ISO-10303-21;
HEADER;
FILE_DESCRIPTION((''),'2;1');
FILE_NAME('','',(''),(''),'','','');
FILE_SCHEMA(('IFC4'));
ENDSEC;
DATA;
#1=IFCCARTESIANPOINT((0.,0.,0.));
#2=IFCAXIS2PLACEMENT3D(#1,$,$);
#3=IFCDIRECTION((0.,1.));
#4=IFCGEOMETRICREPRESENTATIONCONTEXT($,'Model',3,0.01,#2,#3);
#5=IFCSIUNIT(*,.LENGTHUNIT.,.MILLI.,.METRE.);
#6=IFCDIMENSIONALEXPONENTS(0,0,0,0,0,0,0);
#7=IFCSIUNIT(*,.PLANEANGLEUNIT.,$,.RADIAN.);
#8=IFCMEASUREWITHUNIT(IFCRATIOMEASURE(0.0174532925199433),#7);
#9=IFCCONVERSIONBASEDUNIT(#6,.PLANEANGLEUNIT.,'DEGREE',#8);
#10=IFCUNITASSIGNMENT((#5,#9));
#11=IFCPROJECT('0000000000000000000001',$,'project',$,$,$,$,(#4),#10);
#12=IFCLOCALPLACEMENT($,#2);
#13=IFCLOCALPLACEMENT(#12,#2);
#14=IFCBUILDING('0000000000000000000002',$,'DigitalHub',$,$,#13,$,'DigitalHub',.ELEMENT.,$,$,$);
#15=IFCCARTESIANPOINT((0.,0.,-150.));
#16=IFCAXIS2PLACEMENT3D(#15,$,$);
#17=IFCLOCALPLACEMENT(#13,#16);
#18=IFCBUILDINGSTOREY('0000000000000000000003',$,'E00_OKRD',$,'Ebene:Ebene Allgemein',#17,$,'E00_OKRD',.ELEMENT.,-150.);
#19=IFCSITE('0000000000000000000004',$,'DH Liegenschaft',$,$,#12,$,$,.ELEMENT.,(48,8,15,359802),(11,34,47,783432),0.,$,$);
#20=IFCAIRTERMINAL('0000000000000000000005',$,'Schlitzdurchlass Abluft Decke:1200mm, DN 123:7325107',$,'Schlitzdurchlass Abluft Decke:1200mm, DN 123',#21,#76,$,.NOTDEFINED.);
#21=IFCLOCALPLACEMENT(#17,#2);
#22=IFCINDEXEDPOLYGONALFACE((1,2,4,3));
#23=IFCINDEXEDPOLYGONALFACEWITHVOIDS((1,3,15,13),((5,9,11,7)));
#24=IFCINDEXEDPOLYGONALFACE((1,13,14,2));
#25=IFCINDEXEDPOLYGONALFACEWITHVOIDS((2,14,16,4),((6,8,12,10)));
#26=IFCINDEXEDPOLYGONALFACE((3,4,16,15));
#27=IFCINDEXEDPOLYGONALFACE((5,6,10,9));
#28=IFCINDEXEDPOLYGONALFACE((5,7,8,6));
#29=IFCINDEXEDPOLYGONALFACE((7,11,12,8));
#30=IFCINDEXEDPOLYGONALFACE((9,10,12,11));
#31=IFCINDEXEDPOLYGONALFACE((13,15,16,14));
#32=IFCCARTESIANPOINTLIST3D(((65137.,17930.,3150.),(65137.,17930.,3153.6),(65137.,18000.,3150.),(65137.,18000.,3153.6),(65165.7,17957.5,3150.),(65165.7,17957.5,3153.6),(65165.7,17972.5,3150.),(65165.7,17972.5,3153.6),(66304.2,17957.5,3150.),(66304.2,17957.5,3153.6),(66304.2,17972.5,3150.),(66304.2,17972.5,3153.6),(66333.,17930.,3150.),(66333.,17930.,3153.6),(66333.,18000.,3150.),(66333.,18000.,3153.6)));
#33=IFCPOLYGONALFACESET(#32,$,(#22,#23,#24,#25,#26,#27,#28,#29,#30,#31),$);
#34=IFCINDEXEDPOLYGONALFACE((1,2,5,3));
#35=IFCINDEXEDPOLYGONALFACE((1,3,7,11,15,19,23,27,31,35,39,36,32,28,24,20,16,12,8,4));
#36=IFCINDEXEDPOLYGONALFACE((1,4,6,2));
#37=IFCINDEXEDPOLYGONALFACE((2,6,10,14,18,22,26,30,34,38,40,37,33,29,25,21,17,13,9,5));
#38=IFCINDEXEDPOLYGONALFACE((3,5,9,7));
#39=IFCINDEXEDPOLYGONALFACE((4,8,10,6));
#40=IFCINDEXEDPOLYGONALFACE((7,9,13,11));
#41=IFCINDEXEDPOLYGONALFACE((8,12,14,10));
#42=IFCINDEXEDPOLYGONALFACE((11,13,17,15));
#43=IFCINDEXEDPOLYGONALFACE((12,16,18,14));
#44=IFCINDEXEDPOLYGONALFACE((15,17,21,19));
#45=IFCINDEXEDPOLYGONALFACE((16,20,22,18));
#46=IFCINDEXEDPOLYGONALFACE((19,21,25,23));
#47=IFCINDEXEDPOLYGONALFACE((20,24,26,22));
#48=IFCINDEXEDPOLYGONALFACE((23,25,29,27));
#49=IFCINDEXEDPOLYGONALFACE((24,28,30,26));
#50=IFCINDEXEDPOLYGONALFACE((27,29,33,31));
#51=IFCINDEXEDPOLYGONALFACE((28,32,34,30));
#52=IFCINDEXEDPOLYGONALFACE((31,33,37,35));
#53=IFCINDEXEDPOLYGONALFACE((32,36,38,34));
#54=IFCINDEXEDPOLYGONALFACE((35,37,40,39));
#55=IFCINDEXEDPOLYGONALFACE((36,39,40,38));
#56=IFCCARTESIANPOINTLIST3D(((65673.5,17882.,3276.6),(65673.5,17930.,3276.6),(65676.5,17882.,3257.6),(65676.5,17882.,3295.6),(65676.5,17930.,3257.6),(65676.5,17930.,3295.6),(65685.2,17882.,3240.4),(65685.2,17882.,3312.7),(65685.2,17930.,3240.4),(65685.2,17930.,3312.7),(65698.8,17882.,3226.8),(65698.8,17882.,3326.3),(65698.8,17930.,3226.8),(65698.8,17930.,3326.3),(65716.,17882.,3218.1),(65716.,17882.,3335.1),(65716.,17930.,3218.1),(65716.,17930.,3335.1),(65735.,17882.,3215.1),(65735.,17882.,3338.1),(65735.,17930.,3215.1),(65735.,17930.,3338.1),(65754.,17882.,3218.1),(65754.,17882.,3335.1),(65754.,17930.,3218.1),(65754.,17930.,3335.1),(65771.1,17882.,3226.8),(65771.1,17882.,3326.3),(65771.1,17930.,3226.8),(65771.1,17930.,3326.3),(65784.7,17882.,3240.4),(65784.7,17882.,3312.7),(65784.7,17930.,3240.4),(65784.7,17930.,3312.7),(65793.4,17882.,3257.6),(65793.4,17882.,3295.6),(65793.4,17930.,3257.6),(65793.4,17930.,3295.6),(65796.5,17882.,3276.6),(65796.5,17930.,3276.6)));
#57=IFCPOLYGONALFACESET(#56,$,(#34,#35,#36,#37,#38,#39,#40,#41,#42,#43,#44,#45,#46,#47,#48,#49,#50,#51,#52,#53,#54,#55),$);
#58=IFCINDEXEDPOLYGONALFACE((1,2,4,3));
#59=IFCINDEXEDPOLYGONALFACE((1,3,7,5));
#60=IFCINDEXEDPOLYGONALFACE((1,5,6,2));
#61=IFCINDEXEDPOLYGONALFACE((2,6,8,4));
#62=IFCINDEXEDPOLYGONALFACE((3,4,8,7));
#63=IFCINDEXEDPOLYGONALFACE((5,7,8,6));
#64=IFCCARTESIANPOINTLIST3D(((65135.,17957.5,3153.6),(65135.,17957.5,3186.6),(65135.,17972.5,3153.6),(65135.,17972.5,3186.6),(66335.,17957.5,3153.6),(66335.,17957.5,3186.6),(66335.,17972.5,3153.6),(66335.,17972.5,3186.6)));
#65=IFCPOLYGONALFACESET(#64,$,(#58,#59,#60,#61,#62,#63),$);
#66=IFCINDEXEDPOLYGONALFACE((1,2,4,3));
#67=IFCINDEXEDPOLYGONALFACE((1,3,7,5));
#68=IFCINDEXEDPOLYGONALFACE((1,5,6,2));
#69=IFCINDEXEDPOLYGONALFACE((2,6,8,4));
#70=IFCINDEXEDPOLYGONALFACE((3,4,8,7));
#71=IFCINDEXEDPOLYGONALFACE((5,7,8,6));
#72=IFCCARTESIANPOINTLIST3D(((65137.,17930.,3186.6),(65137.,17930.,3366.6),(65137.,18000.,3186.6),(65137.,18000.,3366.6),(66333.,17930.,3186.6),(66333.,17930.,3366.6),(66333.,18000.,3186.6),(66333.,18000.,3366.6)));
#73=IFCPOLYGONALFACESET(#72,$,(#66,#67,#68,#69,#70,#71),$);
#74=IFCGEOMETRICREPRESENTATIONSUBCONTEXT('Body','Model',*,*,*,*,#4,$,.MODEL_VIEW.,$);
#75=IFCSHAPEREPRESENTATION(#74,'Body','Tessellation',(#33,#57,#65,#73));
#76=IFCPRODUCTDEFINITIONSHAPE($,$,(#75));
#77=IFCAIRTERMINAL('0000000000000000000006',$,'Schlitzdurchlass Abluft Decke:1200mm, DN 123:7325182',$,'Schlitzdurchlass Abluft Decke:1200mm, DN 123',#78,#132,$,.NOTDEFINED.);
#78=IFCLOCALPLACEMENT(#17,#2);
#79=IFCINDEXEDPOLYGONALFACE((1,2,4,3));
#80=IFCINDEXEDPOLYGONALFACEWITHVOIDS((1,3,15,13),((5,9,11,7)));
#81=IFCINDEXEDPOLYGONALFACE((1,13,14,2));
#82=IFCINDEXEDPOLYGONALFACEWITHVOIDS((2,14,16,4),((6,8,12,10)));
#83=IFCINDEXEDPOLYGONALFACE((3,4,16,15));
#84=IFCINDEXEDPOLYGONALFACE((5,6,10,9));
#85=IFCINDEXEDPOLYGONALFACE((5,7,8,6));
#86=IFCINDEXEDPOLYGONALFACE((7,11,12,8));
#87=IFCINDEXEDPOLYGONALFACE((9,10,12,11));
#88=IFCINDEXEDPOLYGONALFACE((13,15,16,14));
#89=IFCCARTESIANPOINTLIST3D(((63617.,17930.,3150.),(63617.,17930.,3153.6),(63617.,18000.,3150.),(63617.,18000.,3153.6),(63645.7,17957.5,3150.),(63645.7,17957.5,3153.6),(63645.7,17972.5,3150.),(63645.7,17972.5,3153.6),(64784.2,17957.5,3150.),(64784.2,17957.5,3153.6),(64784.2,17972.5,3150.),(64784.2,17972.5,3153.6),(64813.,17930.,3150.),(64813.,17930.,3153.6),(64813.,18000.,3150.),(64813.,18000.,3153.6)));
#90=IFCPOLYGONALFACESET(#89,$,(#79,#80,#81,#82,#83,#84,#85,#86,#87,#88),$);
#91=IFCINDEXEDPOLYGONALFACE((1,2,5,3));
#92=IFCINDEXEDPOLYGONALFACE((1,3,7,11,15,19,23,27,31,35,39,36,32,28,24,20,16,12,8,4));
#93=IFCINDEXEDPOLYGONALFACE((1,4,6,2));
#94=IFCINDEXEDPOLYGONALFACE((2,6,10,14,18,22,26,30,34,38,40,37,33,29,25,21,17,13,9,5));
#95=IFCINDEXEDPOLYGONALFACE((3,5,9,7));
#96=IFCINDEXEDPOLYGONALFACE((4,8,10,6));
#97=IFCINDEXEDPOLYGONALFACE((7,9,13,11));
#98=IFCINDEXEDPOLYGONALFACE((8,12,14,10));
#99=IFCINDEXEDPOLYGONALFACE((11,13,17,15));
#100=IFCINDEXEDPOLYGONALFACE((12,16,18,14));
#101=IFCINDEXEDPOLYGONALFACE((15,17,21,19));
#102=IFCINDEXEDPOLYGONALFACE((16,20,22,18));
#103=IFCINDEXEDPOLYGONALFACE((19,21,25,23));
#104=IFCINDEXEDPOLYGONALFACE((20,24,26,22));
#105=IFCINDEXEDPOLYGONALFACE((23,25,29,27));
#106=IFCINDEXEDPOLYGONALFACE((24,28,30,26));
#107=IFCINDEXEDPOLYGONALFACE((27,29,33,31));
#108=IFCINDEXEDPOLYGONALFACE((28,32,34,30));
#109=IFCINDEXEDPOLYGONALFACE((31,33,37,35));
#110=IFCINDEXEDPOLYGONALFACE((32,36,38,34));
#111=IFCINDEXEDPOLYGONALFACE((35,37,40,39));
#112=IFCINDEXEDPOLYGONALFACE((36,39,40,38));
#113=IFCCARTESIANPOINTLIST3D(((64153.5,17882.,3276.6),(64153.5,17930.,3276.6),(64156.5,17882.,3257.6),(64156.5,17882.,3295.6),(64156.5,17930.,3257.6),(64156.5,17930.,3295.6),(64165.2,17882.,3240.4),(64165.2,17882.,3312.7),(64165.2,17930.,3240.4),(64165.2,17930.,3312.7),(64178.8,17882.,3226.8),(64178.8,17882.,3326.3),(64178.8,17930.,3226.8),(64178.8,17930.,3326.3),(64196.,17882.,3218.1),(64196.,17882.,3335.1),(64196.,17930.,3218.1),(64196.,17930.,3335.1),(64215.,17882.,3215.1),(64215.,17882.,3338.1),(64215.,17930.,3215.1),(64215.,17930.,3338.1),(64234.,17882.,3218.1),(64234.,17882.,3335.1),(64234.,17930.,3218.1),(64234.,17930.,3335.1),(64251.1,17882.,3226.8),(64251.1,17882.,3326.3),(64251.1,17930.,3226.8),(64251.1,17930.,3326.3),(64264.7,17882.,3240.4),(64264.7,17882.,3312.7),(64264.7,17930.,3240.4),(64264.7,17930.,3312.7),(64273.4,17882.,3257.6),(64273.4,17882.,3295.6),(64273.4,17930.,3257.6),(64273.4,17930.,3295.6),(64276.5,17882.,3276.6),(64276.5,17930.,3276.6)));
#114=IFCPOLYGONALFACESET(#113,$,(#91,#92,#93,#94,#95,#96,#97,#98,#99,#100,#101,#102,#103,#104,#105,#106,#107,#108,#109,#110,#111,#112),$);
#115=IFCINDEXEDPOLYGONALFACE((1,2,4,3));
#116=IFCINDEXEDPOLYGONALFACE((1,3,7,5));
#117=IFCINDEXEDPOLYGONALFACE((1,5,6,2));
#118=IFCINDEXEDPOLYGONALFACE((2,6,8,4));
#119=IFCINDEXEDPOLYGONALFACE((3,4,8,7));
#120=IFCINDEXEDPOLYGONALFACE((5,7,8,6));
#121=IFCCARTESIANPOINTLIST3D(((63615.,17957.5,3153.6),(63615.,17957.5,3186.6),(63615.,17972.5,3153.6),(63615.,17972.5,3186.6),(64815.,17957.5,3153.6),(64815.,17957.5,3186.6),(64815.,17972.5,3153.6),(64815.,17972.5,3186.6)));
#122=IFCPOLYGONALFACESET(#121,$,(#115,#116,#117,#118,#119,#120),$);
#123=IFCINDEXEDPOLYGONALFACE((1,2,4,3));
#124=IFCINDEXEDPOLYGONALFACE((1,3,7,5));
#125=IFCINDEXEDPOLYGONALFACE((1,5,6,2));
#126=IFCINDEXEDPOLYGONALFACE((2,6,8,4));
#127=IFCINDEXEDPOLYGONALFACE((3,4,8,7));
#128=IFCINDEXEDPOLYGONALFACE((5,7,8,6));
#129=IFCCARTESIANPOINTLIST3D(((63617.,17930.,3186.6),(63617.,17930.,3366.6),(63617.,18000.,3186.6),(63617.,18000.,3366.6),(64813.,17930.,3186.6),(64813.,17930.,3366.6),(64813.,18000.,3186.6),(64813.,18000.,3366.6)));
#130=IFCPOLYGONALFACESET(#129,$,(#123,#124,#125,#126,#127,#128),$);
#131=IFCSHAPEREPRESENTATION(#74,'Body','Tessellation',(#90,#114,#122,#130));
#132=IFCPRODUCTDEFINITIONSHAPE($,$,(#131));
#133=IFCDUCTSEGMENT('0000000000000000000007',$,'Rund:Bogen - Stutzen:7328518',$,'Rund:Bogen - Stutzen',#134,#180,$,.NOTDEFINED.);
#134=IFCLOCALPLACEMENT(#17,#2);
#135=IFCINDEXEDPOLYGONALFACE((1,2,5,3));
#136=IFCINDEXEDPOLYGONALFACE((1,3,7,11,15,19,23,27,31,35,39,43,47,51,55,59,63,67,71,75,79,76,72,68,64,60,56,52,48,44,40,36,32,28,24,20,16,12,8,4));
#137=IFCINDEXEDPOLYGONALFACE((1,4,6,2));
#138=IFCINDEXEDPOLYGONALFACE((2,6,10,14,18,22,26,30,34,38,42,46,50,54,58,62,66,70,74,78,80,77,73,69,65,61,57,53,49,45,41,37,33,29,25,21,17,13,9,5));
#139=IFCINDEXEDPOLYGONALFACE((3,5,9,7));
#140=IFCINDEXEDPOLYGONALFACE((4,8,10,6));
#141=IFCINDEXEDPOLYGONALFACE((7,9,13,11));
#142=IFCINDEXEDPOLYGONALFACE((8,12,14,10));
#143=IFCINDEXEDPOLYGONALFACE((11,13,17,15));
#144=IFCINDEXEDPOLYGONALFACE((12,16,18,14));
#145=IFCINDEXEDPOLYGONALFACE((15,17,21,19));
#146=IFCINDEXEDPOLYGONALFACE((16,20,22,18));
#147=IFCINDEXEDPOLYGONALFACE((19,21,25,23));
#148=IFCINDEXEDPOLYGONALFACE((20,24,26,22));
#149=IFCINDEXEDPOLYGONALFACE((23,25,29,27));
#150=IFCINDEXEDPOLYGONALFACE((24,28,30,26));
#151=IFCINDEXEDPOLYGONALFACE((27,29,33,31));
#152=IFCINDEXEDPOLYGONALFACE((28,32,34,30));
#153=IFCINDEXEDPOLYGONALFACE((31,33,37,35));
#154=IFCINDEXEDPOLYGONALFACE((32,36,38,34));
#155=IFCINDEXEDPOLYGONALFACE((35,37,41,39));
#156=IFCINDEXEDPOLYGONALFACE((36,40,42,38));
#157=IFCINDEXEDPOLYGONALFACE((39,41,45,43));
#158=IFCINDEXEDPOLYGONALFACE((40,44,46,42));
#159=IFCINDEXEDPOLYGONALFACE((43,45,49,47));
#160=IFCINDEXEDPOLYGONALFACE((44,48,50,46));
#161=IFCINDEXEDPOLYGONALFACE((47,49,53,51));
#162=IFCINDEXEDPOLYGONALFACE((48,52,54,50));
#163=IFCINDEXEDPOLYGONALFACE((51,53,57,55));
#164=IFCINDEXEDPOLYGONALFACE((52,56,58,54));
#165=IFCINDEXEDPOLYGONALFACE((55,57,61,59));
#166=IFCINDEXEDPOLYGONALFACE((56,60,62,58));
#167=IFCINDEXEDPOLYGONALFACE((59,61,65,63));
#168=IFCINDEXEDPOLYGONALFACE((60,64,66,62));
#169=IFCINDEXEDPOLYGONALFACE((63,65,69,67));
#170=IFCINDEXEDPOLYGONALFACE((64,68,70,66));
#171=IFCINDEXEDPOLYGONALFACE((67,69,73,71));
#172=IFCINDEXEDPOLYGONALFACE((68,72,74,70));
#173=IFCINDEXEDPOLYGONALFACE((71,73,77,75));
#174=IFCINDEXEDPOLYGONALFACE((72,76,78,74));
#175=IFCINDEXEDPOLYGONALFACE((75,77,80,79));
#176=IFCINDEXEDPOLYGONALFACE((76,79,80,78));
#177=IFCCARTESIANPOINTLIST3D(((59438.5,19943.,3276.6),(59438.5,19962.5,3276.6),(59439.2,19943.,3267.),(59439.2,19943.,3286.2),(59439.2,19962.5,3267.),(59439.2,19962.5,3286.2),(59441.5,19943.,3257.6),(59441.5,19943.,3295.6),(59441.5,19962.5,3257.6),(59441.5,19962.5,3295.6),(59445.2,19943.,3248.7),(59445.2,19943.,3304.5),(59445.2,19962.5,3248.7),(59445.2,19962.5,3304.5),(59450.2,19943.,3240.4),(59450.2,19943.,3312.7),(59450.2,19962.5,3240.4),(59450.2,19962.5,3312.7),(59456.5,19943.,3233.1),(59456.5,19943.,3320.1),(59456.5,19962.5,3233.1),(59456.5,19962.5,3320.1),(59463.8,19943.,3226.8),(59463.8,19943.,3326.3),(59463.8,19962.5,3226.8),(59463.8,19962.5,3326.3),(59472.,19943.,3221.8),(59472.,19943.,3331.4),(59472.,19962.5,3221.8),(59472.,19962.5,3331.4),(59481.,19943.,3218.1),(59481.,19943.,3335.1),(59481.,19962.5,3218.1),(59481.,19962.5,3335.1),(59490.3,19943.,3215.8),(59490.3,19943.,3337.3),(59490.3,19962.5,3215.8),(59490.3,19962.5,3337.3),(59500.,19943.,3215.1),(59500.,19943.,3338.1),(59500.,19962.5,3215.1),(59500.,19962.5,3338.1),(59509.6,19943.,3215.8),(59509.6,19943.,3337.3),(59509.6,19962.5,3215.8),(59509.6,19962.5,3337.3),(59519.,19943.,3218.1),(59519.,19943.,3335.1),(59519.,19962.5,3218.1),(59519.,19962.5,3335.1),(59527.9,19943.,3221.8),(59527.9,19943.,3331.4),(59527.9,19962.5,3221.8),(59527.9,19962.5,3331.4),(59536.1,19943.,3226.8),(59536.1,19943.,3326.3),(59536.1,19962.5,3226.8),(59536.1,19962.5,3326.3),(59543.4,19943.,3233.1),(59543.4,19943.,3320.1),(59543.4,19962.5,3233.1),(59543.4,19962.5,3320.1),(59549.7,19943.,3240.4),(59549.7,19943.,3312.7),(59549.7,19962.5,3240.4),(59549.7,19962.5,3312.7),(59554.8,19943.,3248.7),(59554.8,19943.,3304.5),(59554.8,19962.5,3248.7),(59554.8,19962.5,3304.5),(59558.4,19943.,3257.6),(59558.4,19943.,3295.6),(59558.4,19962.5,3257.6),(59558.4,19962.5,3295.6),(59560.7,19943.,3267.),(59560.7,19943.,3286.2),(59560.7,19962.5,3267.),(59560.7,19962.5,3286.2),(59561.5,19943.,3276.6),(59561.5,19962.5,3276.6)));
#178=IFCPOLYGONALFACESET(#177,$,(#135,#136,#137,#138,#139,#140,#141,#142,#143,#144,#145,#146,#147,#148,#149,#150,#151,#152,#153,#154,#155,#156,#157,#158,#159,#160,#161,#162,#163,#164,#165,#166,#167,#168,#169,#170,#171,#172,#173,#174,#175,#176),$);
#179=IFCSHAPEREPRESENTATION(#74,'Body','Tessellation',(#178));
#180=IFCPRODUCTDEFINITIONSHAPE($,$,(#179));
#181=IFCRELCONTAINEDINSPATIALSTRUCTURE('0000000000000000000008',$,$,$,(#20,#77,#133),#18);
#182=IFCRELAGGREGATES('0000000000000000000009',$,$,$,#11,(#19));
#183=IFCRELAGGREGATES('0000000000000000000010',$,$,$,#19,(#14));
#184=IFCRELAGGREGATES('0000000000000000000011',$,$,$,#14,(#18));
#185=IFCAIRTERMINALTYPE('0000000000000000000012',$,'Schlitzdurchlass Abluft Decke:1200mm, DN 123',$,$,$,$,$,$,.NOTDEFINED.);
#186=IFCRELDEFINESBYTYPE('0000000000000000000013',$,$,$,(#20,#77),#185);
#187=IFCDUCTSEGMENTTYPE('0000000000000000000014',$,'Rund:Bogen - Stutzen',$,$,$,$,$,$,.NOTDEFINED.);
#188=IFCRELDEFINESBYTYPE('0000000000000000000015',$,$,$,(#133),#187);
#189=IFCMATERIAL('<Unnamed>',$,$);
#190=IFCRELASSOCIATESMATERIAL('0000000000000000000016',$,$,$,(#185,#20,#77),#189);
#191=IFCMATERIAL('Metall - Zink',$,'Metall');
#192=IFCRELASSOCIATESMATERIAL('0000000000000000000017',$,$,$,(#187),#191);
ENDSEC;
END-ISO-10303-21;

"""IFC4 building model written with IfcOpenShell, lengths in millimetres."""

from ifc_helpers import new_model, entity, si_unit, converted_unit, direction, frame, origin, place, context, subcontext, project, spatial, indexed_curve, outline, extrude, source, transform, mapped, material, type_object, type_shapes, element, save


model = new_model("IFC4")

# Units and contexts
model_context = context("Model", 3, precision=0.01, world=origin(), true_north=direction((0.0, 1.0)))
body_context = subcontext(model_context, "Body", "Model", "MODEL_VIEW")
ifc_project = project(units=[si_unit("LENGTHUNIT", "METRE", prefix="MILLI"), converted_unit("PLANEANGLEUNIT", "DEGREE", entity("IfcRatioMeasure", 0.0174532925199433), si_unit("PLANEANGLEUNIT", "RADIAN"), dimensions=[0, 0, 0, 0, 0, 0, 0])], contexts=[model_context])

# Site, building, storey
site_placement = place(None, origin())
site = spatial("IfcSite", under=ifc_project, at=site_placement, Name="DH Liegenschaft", CompositionType="ELEMENT", RefLatitude=(48, 8, 15, 359802), RefLongitude=(11, 34, 47, 783432), RefElevation=0.0)
building_placement = place(site_placement, origin())
building = spatial("IfcBuilding", under=site, at=building_placement, Name="DigitalHub", LongName="DigitalHub", CompositionType="ELEMENT")
storey_placement = place(building_placement, frame((0.0, 0.0, -150.0)))
storey = spatial("IfcBuildingStorey", under=building, at=storey_placement, Name="E00_OKRD", ObjectType="Ebene:Ebene Allgemein", LongName="E00_OKRD", CompositionType="ELEMENT", Elevation=-150.0)

# Shared definitions
ifc_material_1 = material(Name="Metall - Zink", Category="Metall")

# Air terminals
ifc_material_2 = material(Name="<Unnamed>")
air_terminal_type_1 = type_object("IfcAirTerminalType", Name="Schlitzdurchlass Abluft Decke:1200mm, DN 123", PredefinedType="NOTDEFINED", material=ifc_material_2)
shared_shape_1 = source(origin(), body_context, "Body", "SweptSolid", [
    extrude(outline(indexed_curve([(-598.0, -35.0), (598.0, -35.0), (598.0, 35.0), (-598.0, 35.0), (-598.0, -35.0)], self_intersect=False), holes=[indexed_curve([(-569.2, -7.5), (-569.2, 7.5), (569.2, 7.5), (569.2, -7.5), (-569.2, -7.5)], self_intersect=False)]), frame((0.0, 0.0, 0.0), z_axis=(0.0, 0.0, 1.0), x_axis=(-1.0, 0.0, 0.0)), (0.0, 0.0, 1.0), 3.6),
    extrude(outline(indexed_curve([(61.5, 0.0), (58.5, 19.0), (49.8, 36.1), (36.1, 49.8), (19.0, 58.5), (0.0, 61.5), (-19.0, 58.5), (-36.1, 49.8), (-49.8, 36.1), (-58.5, 19.0), (-61.5, 0.0), (-58.5, -19.0), (-49.8, -36.1), (-36.1, -49.8), (-19.0, -58.5), (0.0, -61.5), (19.0, -58.5), (36.1, -49.8), (49.8, -36.1), (58.5, -19.0), (61.5, 0.0)], self_intersect=False)), frame((0.0, 35.0, 126.6), z_axis=(0.0, 1.0, 0.0), x_axis=(-1.0, 0.0, 0.0)), (0.0, 0.0, 1.0), 48.0),
    extrude(outline(indexed_curve([(-600.0, -7.5), (600.0, -7.5), (600.0, 7.5), (-600.0, 7.5), (-600.0, -7.5)], self_intersect=False)), frame((0.0, 0.0, 3.6), z_axis=(0.0, 0.0, 1.0), x_axis=(-1.0, 0.0, 0.0)), (0.0, 0.0, 1.0), 33.0),
    extrude(outline(indexed_curve([(-598.0, -35.0), (598.0, -35.0), (598.0, 35.0), (-598.0, 35.0), (-598.0, -35.0)], self_intersect=False)), frame((0.0, 0.0, 36.6), z_axis=(0.0, 0.0, 1.0), x_axis=(-1.0, 0.0, 0.0)), (0.0, 0.0, 1.0), 180.0),
])
type_shapes(air_terminal_type_1, [shared_shape_1])
for number, where, z_axis, x_axis, name in (
    (1, (65735.0, 17965.0, 3150.0), (0.0, 0.0, 1.0), (-1.0, 0.0, 0.0), "Schlitzdurchlass Abluft Decke:1200mm, DN 123:7325107"),
    (2, (64215.0, 17965.0, 3150.0), (0.0, 0.0, 1.0), (-1.0, 0.0, 0.0), "Schlitzdurchlass Abluft Decke:1200mm, DN 123:7325182"),
):
    element("IfcAirTerminal", number, at=place(storey_placement, frame(where, z_axis=z_axis, x_axis=x_axis)), inside=storey, type_object=air_terminal_type_1, material=ifc_material_2, Name=name, ObjectType="Schlitzdurchlass Abluft Decke:1200mm, DN 123", PredefinedType="NOTDEFINED", context=body_context, shape_type="MappedRepresentation", body=[
        mapped(shared_shape_1, transform((0.0, 0.0, 0.0), scale=1.0)),
    ])

# Duct segment
duct_segment_type_1 = type_object("IfcDuctSegmentType", Name="Rund:Bogen - Stutzen", PredefinedType="NOTDEFINED", material=ifc_material_1)
duct_segment_1_placement = place(storey_placement, frame((59436.9, 19943.0, 3213.5)))
element("IfcDuctSegment", 3, at=duct_segment_1_placement, inside=storey, type_object=duct_segment_type_1, Name="Rund:Bogen - Stutzen:7328518", ObjectType="Rund:Bogen - Stutzen", PredefinedType="NOTDEFINED", context=body_context, shape_type="SweptSolid", body=[
    extrude(outline(indexed_curve([(61.5, 0.0), (60.7, 9.6), (58.5, 19.0), (54.8, 27.9), (49.8, 36.1), (43.5, 43.5), (36.1, 49.8), (27.9, 54.8), (19.0, 58.5), (9.6, 60.7), (0.0, 61.5), (-9.6, 60.7), (-19.0, 58.5), (-27.9, 54.8), (-36.1, 49.8), (-43.5, 43.5), (-49.8, 36.1), (-54.8, 27.9), (-58.5, 19.0), (-60.7, 9.6), (-61.5, 0.0), (-60.7, -9.6), (-58.5, -19.0), (-54.8, -27.9), (-49.8, -36.1), (-43.5, -43.5), (-36.1, -49.8), (-27.9, -54.8), (-19.0, -58.5), (-9.6, -60.7), (0.0, -61.5), (9.6, -60.7), (19.0, -58.5), (27.9, -54.8), (36.1, -49.8), (43.5, -43.5), (49.8, -36.1), (54.8, -27.9), (58.5, -19.0), (60.7, -9.6), (61.5, 0.0)], self_intersect=False)), frame((63.1, 0.0, 63.1), z_axis=(0.0, 1.0, 0.0), x_axis=(1.0, 0.0, 0.0)), (0.0, 0.0, 1.0), 19.5),
])

save(model, "model.ifc")
